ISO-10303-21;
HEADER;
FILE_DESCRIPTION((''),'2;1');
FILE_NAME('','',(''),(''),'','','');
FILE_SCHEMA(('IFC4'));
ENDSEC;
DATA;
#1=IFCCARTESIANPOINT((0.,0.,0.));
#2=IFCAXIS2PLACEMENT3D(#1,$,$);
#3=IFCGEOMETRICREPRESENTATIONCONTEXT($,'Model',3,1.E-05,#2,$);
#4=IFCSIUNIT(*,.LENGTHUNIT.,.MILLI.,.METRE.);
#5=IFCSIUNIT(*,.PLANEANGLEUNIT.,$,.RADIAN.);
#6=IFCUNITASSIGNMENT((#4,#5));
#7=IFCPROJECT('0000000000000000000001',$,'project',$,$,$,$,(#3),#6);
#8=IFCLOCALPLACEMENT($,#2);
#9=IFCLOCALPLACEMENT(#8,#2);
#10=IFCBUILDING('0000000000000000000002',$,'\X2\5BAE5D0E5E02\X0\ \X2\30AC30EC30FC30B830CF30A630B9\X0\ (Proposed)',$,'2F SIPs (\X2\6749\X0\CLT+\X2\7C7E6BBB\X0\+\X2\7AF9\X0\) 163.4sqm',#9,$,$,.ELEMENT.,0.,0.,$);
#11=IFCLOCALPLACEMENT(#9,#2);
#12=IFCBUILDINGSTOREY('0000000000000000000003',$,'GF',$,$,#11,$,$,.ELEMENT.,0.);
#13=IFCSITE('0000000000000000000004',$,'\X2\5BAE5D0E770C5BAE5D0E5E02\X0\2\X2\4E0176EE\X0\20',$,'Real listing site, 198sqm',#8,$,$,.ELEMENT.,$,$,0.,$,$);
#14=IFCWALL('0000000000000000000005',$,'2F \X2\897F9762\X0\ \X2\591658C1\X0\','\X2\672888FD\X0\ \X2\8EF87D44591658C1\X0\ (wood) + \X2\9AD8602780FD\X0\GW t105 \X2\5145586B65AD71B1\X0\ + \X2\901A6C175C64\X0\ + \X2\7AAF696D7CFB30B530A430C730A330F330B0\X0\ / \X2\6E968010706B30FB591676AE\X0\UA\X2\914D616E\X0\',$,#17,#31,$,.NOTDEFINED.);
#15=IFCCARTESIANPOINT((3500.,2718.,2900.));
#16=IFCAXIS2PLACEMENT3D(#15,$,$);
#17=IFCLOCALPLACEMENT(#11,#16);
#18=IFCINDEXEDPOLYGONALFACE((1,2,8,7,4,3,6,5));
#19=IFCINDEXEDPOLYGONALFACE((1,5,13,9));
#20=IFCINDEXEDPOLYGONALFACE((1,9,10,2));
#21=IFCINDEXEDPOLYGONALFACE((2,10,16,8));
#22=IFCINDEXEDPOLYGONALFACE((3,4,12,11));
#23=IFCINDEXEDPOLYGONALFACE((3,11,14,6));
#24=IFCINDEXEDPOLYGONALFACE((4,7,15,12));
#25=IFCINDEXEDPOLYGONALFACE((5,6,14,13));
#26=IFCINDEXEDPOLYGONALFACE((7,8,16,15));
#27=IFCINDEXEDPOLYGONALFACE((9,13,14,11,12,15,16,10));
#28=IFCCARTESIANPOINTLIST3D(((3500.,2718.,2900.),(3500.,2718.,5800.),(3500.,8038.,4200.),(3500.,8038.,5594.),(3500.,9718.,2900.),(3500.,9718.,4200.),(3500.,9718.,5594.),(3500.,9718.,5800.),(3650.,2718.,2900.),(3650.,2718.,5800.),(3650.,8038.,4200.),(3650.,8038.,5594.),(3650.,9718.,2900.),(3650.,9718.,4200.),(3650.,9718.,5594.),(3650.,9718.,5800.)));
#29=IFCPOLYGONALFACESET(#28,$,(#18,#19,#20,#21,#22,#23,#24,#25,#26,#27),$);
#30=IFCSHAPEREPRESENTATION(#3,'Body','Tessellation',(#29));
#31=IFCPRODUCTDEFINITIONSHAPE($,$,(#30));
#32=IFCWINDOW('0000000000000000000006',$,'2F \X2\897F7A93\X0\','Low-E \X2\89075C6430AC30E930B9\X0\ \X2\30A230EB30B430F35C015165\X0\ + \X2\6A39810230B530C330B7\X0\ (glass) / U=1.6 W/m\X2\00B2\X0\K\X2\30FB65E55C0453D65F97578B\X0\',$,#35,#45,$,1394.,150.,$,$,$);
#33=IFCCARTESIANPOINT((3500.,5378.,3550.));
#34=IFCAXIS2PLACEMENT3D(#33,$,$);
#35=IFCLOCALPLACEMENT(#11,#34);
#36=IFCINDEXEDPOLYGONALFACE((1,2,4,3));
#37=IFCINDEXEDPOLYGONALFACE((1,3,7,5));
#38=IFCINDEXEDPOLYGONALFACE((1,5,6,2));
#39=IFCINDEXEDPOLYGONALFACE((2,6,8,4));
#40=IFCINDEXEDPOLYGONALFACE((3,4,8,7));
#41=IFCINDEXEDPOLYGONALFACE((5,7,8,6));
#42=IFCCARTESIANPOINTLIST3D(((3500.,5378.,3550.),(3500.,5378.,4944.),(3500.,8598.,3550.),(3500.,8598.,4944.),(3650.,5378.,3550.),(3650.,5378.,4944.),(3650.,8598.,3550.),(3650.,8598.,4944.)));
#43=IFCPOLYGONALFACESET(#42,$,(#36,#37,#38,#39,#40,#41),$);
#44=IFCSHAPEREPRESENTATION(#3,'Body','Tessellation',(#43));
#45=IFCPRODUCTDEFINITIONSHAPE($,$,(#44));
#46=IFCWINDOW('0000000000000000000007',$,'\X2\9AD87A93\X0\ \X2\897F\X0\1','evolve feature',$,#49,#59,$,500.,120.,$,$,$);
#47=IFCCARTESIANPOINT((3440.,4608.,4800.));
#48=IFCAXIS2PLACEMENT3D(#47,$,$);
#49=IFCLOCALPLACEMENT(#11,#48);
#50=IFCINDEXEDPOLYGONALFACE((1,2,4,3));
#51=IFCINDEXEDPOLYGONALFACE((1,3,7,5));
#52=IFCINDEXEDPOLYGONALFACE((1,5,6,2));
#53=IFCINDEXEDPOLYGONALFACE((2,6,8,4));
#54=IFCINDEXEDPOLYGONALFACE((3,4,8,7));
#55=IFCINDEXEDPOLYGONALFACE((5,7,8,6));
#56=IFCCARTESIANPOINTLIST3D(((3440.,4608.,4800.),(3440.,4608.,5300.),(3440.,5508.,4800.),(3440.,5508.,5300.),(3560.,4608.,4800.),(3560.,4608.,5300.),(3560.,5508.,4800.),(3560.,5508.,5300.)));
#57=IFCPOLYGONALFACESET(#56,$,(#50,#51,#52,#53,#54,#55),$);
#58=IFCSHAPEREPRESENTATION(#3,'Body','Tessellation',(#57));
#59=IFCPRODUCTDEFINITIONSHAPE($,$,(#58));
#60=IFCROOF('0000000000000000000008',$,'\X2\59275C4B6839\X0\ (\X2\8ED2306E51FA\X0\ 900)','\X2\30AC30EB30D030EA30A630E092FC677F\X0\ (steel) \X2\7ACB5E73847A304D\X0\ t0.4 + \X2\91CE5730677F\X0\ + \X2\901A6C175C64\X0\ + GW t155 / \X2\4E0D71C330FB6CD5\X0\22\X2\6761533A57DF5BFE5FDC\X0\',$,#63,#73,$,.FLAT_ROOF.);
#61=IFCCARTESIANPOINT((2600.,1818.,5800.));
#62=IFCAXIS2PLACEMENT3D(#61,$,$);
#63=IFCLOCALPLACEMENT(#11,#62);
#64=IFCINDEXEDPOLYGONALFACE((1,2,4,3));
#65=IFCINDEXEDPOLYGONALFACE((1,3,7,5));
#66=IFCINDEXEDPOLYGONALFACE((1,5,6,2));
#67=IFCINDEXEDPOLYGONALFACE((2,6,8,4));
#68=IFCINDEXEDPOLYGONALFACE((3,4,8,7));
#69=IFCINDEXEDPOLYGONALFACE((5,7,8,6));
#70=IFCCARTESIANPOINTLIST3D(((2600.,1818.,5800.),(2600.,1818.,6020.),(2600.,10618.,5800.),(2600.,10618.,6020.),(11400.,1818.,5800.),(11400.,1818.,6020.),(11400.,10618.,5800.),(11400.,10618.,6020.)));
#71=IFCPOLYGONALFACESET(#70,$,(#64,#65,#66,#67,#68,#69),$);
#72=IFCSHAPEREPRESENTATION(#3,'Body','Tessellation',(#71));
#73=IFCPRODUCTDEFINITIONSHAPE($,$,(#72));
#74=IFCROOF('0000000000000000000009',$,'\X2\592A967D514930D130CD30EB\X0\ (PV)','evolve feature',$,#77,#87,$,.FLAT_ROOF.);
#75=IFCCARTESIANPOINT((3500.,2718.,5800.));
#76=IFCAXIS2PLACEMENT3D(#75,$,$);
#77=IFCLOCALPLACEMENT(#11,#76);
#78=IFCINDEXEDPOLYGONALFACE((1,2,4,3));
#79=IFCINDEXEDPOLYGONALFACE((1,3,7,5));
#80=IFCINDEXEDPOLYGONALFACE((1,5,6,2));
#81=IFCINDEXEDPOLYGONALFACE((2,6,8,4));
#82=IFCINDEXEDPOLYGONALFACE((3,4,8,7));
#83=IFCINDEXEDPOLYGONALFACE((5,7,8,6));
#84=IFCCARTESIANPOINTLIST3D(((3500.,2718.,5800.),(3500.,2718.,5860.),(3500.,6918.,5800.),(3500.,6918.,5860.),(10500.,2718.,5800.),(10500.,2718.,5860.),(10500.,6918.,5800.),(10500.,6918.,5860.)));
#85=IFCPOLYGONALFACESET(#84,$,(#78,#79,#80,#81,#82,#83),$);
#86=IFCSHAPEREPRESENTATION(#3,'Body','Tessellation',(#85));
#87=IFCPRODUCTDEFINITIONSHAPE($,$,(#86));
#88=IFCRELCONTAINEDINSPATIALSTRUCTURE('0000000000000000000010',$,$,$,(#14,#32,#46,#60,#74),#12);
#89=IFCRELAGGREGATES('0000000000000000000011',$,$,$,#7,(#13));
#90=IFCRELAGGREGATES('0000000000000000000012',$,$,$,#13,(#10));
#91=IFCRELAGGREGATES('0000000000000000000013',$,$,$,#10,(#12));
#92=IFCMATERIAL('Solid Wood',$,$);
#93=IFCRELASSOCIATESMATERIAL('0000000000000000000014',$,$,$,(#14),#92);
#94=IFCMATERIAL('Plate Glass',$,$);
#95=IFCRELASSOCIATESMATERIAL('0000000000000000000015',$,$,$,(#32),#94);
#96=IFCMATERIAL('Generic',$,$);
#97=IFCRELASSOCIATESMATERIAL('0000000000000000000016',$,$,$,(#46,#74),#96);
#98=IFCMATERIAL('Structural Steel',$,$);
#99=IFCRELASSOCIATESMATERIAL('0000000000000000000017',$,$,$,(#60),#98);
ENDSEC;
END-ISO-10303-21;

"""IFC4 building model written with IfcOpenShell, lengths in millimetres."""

from ifc_helpers import new_model, si_unit, frame, frame_2d, origin, place, context, project, spatial, rectangle, extrude, material, element, fill, save


model = new_model("IFC4")

# Units and contexts
model_context = context("Model", 3, precision=1e-05, world=origin())
ifc_project = project(units=[si_unit("LENGTHUNIT", "METRE", prefix="MILLI"), si_unit("PLANEANGLEUNIT", "RADIAN")], contexts=[model_context])

# Site, building, storey
site_placement = place(None, origin())
site = spatial("IfcSite", under=ifc_project, at=site_placement, Name="宮崎県宮崎市2丁目20", ObjectType="Real listing site, 198sqm", CompositionType="ELEMENT", RefElevation=0.0)
building_placement = place(site_placement, origin())
building = spatial("IfcBuilding", under=site, at=building_placement, Name="宮崎市 ガレージハウス (Proposed)", ObjectType="2F SIPs (杉CLT+籾殻+竹) 163.4sqm", CompositionType="ELEMENT", ElevationOfRefHeight=0.0, ElevationOfTerrain=0.0)
storey_placement = place(building_placement, origin())
storey = spatial("IfcBuildingStorey", under=building, at=storey_placement, Name="GF", CompositionType="ELEMENT", Elevation=0.0)

# Shared definitions
ifc_material_1 = material(Name="Solid Wood")
ifc_material_2 = material(Name="Generic")

# Shared definitions
ifc_material_3 = material(Name="Plate Glass")

# Wall, openings, windows
wall_1_placement = place(storey_placement, frame((3500.0, 2718.0, 2900.0)))
wall_1 = element("IfcWall", 1, at=wall_1_placement, inside=storey, material=ifc_material_1, Name="2F 西面 外壁", Description="木製 軸組外壁 (wood) + 高性能GW t105 充填断熱 + 通気層 + 窯業系サイディング / 準耐火・外皮UA配慮", PredefinedType="NOTDEFINED", context=model_context, shape_type="SweptSolid", body=[
    extrude(rectangle(XDim=150.0, YDim=7000.0, at=frame_2d((75.0, 3500.0))), frame((3500.0, 2718.0, 2900.0)), (0.0, 0.0, 1.0), 2900.0),
])
opening_1_placement = place(storey_placement, frame((3500.0, 5378.0, 3550.0)))
opening_1 = element("IfcOpeningElement", 2, at=opening_1_placement, cuts=wall_1, PredefinedType="NOTDEFINED", context=model_context, shape_type="SweptSolid", body=[
    extrude(rectangle(XDim=150.0, YDim=3220.0, at=frame_2d((75.0, 1610.0))), frame((3500.0, 5378.0, 3550.0)), (0.0, 0.0, 1.0), 1394.0),
])
opening_2_placement = place(storey_placement, frame((3440.0, 4608.0, 4800.0)))
opening_2 = element("IfcOpeningElement", 3, at=opening_2_placement, cuts=wall_1, PredefinedType="NOTDEFINED", context=model_context, shape_type="SweptSolid", body=[
    extrude(rectangle(XDim=120.0, YDim=900.0, at=frame_2d((60.0, 450.0))), frame((3440.0, 4608.0, 4800.0)), (0.0, 0.0, 1.0), 500.0),
])
window_1_placement = place(storey_placement, frame((3500.0, 5378.0, 3550.0)))
window_1 = element("IfcWindow", 4, at=window_1_placement, inside=storey, material=ifc_material_3, Name="2F 西窓", Description="Low-E 複層ガラス アルゴン封入 + 樹脂サッシ (glass) / U=1.6 W/m²K・日射取得型", OverallHeight=1394.0, OverallWidth=150.0, context=model_context, shape_type="SweptSolid", body=[
    extrude(rectangle(XDim=150.0, YDim=3220.0, at=frame_2d((75.0, 1610.0))), frame((3500.0, 5378.0, 3550.0)), (0.0, 0.0, 1.0), 1394.0),
])
fill(opening_1, window_1)
window_2_placement = place(storey_placement, frame((3440.0, 4608.0, 4800.0)))
window_2 = element("IfcWindow", 5, at=window_2_placement, inside=storey, material=ifc_material_2, Name="高窓 西1", Description="evolve feature", OverallHeight=500.0, OverallWidth=120.0, context=model_context, shape_type="SweptSolid", body=[
    extrude(rectangle(XDim=120.0, YDim=900.0, at=frame_2d((60.0, 450.0))), frame((3440.0, 4608.0, 4800.0)), (0.0, 0.0, 1.0), 500.0),
])
fill(opening_2, window_2)

# Roofs
ifc_material_4 = material(Name="Structural Steel")
roof_1_placement = place(storey_placement, frame((2600.0, 1818.0, 5800.0)))
element("IfcRoof", 6, at=roof_1_placement, inside=storey, material=ifc_material_4, Name="大屋根 (軒の出 900)", Description="ガルバリウム鋼板 (steel) 立平葺き t0.4 + 野地板 + 通気層 + GW t155 / 不燃・法22条区域対応", PredefinedType="FLAT_ROOF", context=model_context, shape_type="SweptSolid", body=[
    extrude(rectangle(XDim=8800.0, YDim=8800.0, at=frame_2d((4400.0, 4400.0))), frame((2600.0, 1818.0, 5800.0)), (0.0, 0.0, 1.0), 220.0),
])
roof_2_placement = place(storey_placement, frame((3500.0, 2718.0, 5800.0)))
element("IfcRoof", 7, at=roof_2_placement, inside=storey, material=ifc_material_2, Name="太陽光パネル (PV)", Description="evolve feature", PredefinedType="FLAT_ROOF", context=model_context, shape_type="SweptSolid", body=[
    extrude(rectangle(XDim=7000.0, YDim=4200.0, at=frame_2d((3500.0, 2100.0))), frame((3500.0, 2718.0, 5800.0)), (0.0, 0.0, 1.0), 60.0),
])

save(model, "model.ifc")
